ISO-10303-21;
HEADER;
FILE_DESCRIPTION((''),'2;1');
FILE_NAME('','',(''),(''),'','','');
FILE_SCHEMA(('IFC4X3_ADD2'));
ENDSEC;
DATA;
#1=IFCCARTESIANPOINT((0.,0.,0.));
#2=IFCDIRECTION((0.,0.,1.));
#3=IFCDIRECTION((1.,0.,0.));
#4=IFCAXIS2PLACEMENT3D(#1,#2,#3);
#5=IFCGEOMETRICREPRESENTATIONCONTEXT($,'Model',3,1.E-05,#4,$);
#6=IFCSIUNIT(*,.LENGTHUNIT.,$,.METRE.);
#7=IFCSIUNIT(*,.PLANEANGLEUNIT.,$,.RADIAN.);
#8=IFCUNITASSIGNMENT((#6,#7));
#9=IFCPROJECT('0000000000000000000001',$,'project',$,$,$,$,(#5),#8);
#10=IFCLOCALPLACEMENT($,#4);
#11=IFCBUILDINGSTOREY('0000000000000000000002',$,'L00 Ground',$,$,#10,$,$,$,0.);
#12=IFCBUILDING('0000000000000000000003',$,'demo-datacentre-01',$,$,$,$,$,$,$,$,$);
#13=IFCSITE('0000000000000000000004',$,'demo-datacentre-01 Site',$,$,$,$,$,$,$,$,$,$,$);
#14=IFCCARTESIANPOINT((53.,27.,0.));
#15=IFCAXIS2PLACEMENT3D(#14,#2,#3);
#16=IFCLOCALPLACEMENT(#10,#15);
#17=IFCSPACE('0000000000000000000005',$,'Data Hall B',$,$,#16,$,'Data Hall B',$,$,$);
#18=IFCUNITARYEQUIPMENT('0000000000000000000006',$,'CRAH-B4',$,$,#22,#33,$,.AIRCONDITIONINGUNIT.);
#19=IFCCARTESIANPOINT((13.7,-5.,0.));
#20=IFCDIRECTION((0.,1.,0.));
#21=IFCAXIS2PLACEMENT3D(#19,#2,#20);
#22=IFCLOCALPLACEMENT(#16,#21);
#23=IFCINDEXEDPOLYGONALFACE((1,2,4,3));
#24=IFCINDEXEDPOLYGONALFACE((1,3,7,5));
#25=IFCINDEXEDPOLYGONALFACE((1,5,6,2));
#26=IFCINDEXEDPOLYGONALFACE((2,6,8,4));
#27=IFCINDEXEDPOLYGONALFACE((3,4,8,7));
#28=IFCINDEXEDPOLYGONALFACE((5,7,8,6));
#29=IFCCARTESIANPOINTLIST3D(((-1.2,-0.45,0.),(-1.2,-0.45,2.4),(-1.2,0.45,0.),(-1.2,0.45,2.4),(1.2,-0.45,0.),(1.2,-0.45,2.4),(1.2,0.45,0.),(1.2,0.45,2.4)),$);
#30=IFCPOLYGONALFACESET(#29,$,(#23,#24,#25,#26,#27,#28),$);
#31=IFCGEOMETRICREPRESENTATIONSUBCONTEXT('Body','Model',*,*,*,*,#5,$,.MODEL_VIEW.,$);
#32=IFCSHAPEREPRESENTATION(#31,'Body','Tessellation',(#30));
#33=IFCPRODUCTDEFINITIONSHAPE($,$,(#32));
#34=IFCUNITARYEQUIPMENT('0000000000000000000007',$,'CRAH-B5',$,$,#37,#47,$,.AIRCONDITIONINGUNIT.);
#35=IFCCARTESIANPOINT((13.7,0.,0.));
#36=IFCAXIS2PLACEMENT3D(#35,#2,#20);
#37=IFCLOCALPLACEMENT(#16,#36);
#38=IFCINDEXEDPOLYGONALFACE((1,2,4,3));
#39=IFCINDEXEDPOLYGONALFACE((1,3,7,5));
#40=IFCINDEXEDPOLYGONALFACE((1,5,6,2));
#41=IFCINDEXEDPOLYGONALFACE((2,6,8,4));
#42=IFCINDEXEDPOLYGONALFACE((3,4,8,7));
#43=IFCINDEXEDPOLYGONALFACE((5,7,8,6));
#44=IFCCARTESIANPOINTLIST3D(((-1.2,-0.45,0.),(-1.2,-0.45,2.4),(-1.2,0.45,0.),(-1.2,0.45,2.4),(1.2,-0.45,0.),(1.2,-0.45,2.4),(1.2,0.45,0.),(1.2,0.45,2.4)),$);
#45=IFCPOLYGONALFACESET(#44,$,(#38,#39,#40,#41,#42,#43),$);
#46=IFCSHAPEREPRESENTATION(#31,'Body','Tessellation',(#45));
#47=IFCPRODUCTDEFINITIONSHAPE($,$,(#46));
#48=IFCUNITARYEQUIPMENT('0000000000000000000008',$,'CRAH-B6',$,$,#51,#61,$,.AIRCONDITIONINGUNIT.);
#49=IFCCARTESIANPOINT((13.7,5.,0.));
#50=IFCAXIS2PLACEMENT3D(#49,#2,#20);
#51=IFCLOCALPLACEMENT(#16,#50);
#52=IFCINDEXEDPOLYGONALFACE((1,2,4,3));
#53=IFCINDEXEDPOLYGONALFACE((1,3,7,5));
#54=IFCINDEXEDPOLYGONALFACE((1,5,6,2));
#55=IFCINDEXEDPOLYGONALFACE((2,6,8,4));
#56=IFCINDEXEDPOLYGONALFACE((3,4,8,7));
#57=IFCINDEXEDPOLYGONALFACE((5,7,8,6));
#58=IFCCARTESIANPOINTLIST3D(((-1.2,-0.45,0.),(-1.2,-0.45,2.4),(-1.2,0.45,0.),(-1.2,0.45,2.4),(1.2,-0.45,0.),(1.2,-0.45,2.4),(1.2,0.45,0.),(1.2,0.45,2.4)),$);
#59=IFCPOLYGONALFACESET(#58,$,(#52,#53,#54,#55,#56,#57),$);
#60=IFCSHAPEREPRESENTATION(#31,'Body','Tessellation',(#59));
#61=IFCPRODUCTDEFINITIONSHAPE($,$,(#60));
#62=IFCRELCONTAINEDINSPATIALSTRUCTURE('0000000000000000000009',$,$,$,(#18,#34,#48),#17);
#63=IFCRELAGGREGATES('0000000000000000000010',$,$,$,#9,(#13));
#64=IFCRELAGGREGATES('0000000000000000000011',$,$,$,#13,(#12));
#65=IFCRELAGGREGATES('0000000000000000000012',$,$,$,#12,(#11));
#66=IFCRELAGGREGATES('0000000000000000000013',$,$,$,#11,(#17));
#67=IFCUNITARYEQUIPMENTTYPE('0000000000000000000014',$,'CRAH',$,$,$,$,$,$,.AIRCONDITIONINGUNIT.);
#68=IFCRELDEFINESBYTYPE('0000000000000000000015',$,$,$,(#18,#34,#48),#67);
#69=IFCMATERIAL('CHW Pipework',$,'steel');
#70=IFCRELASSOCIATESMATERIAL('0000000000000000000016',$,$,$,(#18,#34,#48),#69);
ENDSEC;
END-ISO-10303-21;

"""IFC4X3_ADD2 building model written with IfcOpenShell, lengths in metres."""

from ifc_helpers import new_model, si_unit, frame, origin_with_axes, place, context, subcontext, project, spatial, rectangle, extrude, material, type_object, element, save


model = new_model("IFC4X3_ADD2")

# Units and contexts
model_context = context("Model", 3, precision=1e-05, world=origin_with_axes())
body_context = subcontext(model_context, "Body", "Model", "MODEL_VIEW")
ifc_project = project(units=[si_unit("LENGTHUNIT", "METRE"), si_unit("PLANEANGLEUNIT", "RADIAN")], contexts=[model_context])

# Site, building, storey
site = spatial("IfcSite", under=ifc_project, Name="demo-datacentre-01 Site")
building = spatial("IfcBuilding", under=site, Name="demo-datacentre-01")
storey_placement = place(None, origin_with_axes())
storey = spatial("IfcBuildingStorey", under=building, at=storey_placement, Name="L00 Ground", Elevation=0.0)

# Shared definitions
ifc_material = material(Name="CHW Pipework", Category="steel")

# Shared definitions
space_placement = place(storey_placement, frame((53.0, 27.0, 0.0), z_axis=(0.0, 0.0, 1.0), x_axis=(1.0, 0.0, 0.0)))
space = spatial("IfcSpace", under=storey, at=space_placement, Name="Data Hall B", LongName="Data Hall B")

# Unitary equipment
unitary_equipment_type = type_object("IfcUnitaryEquipmentType", Name="CRAH", PredefinedType="AIRCONDITIONINGUNIT")
for number, where, z_axis, x_axis, name in (
    (1, (13.7, -5.0, 0.0), (0.0, 0.0, 1.0), (0.0, 1.0, 0.0), "CRAH-B4"),
    (2, (13.7, 0.0, 0.0), (0.0, 0.0, 1.0), (0.0, 1.0, 0.0), "CRAH-B5"),
    (3, (13.7, 5.0, 0.0), (0.0, 0.0, 1.0), (0.0, 1.0, 0.0), "CRAH-B6"),
):
    element("IfcUnitaryEquipment", number, at=place(space_placement, frame(where, z_axis=z_axis, x_axis=x_axis)), inside=space, type_object=unitary_equipment_type, material=ifc_material, Name=name, PredefinedType="AIRCONDITIONINGUNIT", context=body_context, shape_type="SweptSolid", body=[
        extrude(rectangle(XDim=2.4, YDim=0.9), origin_with_axes(), (0.0, 0.0, 1.0), 2.4),
    ])

save(model, "model.ifc")
